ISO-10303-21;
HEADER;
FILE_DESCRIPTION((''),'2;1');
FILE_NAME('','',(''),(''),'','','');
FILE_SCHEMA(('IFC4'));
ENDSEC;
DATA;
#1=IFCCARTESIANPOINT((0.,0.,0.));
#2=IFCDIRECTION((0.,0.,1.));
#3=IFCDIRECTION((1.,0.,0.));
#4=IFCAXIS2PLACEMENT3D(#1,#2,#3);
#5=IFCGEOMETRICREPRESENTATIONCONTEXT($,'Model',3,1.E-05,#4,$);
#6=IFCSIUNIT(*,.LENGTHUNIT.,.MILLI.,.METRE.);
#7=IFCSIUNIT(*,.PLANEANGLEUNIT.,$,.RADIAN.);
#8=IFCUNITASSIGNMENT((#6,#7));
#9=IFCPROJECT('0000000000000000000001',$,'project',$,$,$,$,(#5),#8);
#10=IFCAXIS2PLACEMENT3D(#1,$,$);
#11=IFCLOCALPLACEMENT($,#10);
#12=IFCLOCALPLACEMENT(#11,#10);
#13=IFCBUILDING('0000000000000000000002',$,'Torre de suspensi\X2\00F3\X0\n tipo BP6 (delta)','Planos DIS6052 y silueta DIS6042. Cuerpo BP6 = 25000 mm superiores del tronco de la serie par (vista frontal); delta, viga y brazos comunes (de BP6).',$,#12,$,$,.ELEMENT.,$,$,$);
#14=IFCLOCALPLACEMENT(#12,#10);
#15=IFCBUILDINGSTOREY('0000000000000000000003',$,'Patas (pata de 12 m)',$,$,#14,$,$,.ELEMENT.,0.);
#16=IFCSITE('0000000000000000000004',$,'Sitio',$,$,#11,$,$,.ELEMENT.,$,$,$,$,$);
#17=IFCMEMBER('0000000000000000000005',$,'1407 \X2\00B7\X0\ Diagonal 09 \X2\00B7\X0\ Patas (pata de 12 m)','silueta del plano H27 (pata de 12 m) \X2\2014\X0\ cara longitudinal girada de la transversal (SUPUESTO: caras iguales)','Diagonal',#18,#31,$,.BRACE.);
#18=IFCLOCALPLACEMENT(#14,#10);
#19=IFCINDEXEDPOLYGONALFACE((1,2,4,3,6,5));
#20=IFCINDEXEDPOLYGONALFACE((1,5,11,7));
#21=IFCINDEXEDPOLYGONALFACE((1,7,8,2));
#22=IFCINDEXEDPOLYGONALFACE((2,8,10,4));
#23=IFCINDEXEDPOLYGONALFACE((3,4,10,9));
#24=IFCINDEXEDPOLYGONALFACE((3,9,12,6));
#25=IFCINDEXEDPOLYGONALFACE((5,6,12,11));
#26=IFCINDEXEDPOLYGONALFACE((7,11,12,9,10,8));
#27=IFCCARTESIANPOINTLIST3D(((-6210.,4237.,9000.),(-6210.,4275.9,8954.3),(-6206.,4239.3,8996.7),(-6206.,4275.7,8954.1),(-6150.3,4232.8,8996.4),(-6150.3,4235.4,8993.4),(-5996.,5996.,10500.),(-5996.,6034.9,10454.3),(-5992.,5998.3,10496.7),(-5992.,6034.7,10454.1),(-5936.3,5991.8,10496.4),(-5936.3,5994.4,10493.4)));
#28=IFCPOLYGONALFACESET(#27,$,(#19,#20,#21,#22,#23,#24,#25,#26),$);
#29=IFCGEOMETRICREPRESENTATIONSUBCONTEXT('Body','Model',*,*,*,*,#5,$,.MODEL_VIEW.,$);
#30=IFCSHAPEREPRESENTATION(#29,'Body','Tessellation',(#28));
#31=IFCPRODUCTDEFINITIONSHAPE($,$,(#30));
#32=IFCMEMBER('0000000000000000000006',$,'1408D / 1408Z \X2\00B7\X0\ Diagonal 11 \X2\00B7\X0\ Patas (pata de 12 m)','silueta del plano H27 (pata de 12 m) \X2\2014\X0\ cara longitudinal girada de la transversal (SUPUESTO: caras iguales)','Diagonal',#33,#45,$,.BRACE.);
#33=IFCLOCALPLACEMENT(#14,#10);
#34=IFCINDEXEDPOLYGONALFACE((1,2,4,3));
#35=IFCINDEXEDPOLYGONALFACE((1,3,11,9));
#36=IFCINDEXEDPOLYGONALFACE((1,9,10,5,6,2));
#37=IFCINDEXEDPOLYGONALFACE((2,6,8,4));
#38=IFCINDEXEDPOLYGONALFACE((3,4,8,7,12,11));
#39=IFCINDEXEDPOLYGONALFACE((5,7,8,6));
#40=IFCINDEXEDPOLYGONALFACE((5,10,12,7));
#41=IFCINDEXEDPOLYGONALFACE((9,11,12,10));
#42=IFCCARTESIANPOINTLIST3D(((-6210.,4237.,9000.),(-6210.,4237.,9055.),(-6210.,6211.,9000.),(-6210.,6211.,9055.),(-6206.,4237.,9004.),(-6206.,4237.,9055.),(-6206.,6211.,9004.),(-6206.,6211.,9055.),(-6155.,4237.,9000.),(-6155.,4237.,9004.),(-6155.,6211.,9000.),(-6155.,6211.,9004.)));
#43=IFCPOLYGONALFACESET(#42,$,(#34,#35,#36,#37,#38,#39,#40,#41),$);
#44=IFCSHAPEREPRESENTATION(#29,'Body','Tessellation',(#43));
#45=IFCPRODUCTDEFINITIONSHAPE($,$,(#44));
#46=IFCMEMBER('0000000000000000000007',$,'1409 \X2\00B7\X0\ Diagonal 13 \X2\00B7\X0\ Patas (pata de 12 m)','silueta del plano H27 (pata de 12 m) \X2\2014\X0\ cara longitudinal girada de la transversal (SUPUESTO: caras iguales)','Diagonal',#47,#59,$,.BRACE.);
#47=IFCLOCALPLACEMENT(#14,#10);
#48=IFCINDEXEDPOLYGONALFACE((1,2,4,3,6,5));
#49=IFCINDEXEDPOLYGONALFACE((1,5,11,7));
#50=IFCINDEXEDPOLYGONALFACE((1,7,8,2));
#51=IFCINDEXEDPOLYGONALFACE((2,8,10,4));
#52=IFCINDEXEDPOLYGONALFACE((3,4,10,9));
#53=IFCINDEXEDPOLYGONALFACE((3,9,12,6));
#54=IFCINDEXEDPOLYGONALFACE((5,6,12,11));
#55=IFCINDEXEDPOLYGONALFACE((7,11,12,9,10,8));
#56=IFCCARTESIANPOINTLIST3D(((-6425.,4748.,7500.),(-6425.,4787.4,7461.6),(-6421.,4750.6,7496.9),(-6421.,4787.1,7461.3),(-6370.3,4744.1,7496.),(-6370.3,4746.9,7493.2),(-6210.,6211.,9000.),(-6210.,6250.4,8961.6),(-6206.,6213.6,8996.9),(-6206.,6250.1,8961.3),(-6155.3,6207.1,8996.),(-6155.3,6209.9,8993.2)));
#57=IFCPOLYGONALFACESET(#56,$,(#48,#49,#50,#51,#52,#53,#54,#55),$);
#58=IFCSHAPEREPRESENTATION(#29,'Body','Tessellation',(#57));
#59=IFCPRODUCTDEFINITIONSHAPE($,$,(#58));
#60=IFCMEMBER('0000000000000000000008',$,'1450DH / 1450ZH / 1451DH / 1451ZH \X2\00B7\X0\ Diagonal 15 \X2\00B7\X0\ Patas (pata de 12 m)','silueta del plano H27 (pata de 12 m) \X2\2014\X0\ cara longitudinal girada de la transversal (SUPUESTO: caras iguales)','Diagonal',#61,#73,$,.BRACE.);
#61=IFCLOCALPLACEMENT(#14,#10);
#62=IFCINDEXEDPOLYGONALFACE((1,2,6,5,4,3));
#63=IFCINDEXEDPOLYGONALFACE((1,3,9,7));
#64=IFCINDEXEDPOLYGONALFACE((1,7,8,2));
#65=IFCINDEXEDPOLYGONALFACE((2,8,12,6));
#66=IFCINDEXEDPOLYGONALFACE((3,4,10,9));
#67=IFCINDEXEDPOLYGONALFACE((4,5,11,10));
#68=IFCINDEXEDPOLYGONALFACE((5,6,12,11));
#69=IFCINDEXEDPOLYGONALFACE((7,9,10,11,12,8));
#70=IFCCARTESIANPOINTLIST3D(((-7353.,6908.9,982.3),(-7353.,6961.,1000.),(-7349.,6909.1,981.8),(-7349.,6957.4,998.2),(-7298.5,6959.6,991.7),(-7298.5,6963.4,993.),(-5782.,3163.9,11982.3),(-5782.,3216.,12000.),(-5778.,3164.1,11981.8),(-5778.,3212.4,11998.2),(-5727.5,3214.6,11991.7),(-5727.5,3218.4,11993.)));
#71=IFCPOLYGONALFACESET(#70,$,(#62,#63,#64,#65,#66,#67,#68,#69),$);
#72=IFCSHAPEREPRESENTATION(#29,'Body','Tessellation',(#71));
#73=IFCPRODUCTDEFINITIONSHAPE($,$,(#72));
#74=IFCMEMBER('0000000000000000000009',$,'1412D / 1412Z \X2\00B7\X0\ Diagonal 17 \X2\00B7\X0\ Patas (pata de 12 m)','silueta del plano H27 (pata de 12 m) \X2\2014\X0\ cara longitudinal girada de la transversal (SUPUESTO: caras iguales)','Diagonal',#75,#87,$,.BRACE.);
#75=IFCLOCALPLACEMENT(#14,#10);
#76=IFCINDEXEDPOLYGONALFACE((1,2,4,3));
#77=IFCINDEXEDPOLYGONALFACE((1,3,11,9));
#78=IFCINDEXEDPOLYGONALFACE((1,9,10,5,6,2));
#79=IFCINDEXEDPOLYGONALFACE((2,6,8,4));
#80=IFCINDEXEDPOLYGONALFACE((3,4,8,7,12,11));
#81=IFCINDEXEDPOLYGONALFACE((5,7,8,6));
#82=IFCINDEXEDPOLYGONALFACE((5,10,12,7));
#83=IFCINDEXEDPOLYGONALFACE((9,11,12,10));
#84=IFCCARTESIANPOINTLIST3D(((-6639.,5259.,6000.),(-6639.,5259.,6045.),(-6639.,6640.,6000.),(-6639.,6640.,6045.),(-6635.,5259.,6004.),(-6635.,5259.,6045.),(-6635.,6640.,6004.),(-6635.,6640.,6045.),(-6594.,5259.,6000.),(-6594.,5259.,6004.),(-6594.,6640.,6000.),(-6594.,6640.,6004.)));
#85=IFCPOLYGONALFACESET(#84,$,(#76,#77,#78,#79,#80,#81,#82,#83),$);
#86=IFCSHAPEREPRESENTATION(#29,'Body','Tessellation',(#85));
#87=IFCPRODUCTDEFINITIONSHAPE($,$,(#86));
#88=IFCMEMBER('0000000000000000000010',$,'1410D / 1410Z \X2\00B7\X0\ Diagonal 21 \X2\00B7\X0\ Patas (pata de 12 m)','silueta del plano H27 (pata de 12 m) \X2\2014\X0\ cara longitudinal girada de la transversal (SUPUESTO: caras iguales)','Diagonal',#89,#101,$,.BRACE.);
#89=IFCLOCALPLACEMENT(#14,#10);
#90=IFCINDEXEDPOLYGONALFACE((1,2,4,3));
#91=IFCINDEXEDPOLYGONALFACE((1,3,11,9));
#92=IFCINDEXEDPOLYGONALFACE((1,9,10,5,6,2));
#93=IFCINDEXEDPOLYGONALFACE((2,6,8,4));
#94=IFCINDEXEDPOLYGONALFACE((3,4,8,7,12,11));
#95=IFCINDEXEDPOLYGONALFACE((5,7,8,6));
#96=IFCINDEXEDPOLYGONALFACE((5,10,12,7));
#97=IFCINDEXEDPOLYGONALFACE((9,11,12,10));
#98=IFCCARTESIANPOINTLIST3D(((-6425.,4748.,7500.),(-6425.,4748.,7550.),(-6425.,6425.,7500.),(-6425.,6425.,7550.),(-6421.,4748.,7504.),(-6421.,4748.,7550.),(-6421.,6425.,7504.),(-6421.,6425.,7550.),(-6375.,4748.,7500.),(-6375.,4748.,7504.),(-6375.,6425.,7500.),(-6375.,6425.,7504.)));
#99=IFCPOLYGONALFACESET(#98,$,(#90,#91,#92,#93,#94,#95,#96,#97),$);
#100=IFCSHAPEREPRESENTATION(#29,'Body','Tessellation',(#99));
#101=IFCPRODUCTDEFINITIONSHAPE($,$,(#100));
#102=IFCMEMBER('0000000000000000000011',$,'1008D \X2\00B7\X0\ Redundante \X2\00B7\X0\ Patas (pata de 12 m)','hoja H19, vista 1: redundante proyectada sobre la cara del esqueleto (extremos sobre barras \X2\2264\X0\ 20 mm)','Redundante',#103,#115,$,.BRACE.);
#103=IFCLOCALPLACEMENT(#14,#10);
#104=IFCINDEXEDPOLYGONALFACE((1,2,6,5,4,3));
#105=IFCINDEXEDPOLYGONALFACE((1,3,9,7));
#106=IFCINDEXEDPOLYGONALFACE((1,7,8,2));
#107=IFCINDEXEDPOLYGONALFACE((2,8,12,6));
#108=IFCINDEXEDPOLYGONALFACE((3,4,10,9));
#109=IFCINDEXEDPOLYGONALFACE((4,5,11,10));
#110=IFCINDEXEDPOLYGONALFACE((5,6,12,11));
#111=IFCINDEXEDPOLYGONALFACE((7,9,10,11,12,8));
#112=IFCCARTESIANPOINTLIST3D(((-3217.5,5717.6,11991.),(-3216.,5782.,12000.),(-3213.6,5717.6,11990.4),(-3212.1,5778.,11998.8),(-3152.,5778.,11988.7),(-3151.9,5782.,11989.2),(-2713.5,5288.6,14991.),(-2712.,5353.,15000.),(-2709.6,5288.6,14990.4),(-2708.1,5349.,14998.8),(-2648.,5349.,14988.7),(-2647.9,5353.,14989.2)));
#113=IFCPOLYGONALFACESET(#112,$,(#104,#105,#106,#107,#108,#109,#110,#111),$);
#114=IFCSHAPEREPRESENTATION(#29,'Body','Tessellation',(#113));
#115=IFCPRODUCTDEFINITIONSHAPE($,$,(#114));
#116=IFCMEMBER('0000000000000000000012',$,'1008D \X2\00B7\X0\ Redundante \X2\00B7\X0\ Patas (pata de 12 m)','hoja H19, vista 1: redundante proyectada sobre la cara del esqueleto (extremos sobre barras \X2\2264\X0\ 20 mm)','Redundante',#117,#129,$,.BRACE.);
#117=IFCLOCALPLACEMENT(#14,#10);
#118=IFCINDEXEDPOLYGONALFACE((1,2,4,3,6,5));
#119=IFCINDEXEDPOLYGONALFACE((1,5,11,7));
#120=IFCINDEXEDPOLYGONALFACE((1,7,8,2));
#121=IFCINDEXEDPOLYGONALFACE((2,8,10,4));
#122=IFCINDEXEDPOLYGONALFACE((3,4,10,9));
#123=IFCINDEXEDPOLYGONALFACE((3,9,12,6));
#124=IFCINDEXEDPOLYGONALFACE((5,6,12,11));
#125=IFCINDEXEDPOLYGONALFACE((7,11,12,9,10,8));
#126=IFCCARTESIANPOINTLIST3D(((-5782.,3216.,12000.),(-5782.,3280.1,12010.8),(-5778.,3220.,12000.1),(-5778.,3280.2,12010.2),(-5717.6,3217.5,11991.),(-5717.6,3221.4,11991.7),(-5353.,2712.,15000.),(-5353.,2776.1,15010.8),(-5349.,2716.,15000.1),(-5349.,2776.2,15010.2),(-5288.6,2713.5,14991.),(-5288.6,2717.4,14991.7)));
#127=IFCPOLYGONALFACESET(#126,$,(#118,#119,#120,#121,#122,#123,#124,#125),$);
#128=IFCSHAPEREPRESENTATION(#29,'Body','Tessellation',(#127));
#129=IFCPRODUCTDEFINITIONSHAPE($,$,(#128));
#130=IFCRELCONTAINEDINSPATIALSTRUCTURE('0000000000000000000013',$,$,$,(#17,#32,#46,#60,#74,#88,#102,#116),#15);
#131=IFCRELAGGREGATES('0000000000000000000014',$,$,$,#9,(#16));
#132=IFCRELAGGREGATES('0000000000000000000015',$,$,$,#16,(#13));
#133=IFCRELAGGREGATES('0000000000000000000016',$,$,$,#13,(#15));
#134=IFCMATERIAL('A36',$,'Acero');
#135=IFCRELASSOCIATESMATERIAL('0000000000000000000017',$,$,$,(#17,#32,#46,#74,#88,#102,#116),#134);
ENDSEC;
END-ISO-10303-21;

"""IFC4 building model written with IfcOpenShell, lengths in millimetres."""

from ifc_helpers import new_model, si_unit, frame, frame_2d, origin, origin_with_axes, place, context, subcontext, project, spatial, l_section, extrude, material, element, save


model = new_model("IFC4")

# Units and contexts
model_context = context("Model", 3, precision=1e-05, world=origin_with_axes())
body_context = subcontext(model_context, "Body", "Model", "MODEL_VIEW")
ifc_project = project(units=[si_unit("LENGTHUNIT", "METRE", prefix="MILLI"), si_unit("PLANEANGLEUNIT", "RADIAN")], contexts=[model_context])

# Site, building, storey
site_placement = place(None, origin())
site = spatial("IfcSite", under=ifc_project, at=site_placement, Name="Sitio", CompositionType="ELEMENT")
building_placement = place(site_placement, origin())
building = spatial("IfcBuilding", under=site, at=building_placement, Name="Torre de suspensión tipo BP6 (delta)", Description="Planos DIS6052 y silueta DIS6042. Cuerpo BP6 = 25000 mm superiores del tronco de la serie par (vista frontal); delta, viga y brazos comunes (de BP6).", CompositionType="ELEMENT")
storey_placement = place(building_placement, origin())
storey = spatial("IfcBuildingStorey", under=building, at=storey_placement, Name="Patas (pata de 12 m)", CompositionType="ELEMENT", Elevation=0.0)

# Members
ifc_material_1 = material(Name="A36", Category="Acero")
member_1_placement = place(storey_placement, frame((-6210.0, 4237.0, 9000.0), z_axis=(0.092177, 0.757664, 0.646103), x_axis=(0.995743, -0.070138, -0.059811)))
element("IfcMember", 1, at=member_1_placement, inside=storey, material=ifc_material_1, Name="1407 · Diagonal 09 · Patas (pata de 12 m)", Description="silueta del plano H27 (pata de 12 m) — cara longitudinal girada de la transversal (SUPUESTO: caras iguales)", ObjectType="Diagonal", PredefinedType="BRACE", context=body_context, shape_type="SweptSolid", body=[
    extrude(l_section(Depth=60.0, Width=60.0, Thickness=4.0, at=frame_2d((30.0, 30.0))), None, (0.0, 0.0, 1.0), 2321.6),
])
member_2_placement = place(storey_placement, frame((-6210.0, 6211.0, 9000.0), z_axis=(0.0, -1.0, 0.0), x_axis=(1.0, 0.0, 0.0)))
element("IfcMember", 2, at=member_2_placement, inside=storey, material=ifc_material_1, Name="1408D / 1408Z · Diagonal 11 · Patas (pata de 12 m)", Description="silueta del plano H27 (pata de 12 m) — cara longitudinal girada de la transversal (SUPUESTO: caras iguales)", ObjectType="Diagonal", PredefinedType="BRACE", context=body_context, shape_type="SweptSolid", body=[
    extrude(l_section(Depth=55.0, Width=55.0, Thickness=4.0, at=frame_2d((27.5, 27.5))), None, (0.0, 0.0, 1.0), 1974.0),
])
member_3_placement = place(storey_placement, frame((-6425.0, 4748.0, 7500.0), z_axis=(0.102074, 0.694576, 0.712142), x_axis=(0.994777, -0.07127, -0.073073)))
element("IfcMember", 3, at=member_3_placement, inside=storey, material=ifc_material_1, Name="1409 · Diagonal 13 · Patas (pata de 12 m)", Description="silueta del plano H27 (pata de 12 m) — cara longitudinal girada de la transversal (SUPUESTO: caras iguales)", ObjectType="Diagonal", PredefinedType="BRACE", context=body_context, shape_type="SweptSolid", body=[
    extrude(l_section(Depth=55.0, Width=55.0, Thickness=4.0, at=frame_2d((27.5, 27.5))), None, (0.0, 0.0, 1.0), 2106.3),
])
member_4_placement = place(storey_placement, frame((-5782.0, 3216.0, 12000.0), z_axis=(-0.133979, 0.319383, -0.938107), x_axis=(0.990984, 0.04318, -0.12683)))
element("IfcMember", 4, at=member_4_placement, inside=storey, Name="1450DH / 1450ZH / 1451DH / 1451ZH · Diagonal 15 · Patas (pata de 12 m)", Description="silueta del plano H27 (pata de 12 m) — cara longitudinal girada de la transversal (SUPUESTO: caras iguales)", ObjectType="Diagonal", PredefinedType="BRACE", context=body_context, shape_type="SweptSolid", body=[
    extrude(l_section(Depth=55.0, Width=55.0, Thickness=4.0, at=frame_2d((27.5, 27.5))), None, (0.0, 0.0, 1.0), 11725.7),
])
member_5_placement = place(storey_placement, frame((-6639.0, 6640.0, 6000.0), z_axis=(0.0, -1.0, 0.0), x_axis=(1.0, 0.0, 0.0)))
element("IfcMember", 5, at=member_5_placement, inside=storey, material=ifc_material_1, Name="1412D / 1412Z · Diagonal 17 · Patas (pata de 12 m)", Description="silueta del plano H27 (pata de 12 m) — cara longitudinal girada de la transversal (SUPUESTO: caras iguales)", ObjectType="Diagonal", PredefinedType="BRACE", context=body_context, shape_type="SweptSolid", body=[
    extrude(l_section(Depth=45.0, Width=45.0, Thickness=4.0, at=frame_2d((22.5, 22.5))), None, (0.0, 0.0, 1.0), 1381.0),
])
member_6_placement = place(storey_placement, frame((-6425.0, 6425.0, 7500.0), z_axis=(0.0, -1.0, 0.0), x_axis=(1.0, 0.0, 0.0)))
element("IfcMember", 6, at=member_6_placement, inside=storey, material=ifc_material_1, Name="1410D / 1410Z · Diagonal 21 · Patas (pata de 12 m)", Description="silueta del plano H27 (pata de 12 m) — cara longitudinal girada de la transversal (SUPUESTO: caras iguales)", ObjectType="Diagonal", PredefinedType="BRACE", context=body_context, shape_type="SweptSolid", body=[
    extrude(l_section(Depth=50.0, Width=50.0, Thickness=4.0, at=frame_2d((25.0, 25.0))), None, (0.0, 0.0, 1.0), 1677.0),
])
for number, where, z_axis, x_axis, name in (
    (7, (-3216.0, 5782.0, 12000.0), (0.164055, -0.139642, 0.976517), (-0.023136, -0.990202, -0.137712), "1008D · Redundante · Patas (pata de 12 m)"),
    (8, (-5782.0, 3216.0, 12000.0), (0.139642, -0.164055, 0.976517), (0.990202, 0.023136, -0.137712), "1008D · Redundante · Patas (pata de 12 m)"),
):
    element("IfcMember", number, at=place(storey_placement, frame(where, z_axis=z_axis, x_axis=x_axis)), inside=storey, material=ifc_material_1, Name=name, Description="hoja H19, vista 1: redundante proyectada sobre la cara del esqueleto (extremos sobre barras ≤ 20 mm)", ObjectType="Redundante", PredefinedType="BRACE", context=body_context, shape_type="SweptSolid", body=[
        extrude(l_section(Depth=65.0, Width=65.0, Thickness=4.0, at=frame_2d((32.5, 32.5))), None, (0.0, 0.0, 1.0), 3072.1),
    ])

save(model, "model.ifc")
